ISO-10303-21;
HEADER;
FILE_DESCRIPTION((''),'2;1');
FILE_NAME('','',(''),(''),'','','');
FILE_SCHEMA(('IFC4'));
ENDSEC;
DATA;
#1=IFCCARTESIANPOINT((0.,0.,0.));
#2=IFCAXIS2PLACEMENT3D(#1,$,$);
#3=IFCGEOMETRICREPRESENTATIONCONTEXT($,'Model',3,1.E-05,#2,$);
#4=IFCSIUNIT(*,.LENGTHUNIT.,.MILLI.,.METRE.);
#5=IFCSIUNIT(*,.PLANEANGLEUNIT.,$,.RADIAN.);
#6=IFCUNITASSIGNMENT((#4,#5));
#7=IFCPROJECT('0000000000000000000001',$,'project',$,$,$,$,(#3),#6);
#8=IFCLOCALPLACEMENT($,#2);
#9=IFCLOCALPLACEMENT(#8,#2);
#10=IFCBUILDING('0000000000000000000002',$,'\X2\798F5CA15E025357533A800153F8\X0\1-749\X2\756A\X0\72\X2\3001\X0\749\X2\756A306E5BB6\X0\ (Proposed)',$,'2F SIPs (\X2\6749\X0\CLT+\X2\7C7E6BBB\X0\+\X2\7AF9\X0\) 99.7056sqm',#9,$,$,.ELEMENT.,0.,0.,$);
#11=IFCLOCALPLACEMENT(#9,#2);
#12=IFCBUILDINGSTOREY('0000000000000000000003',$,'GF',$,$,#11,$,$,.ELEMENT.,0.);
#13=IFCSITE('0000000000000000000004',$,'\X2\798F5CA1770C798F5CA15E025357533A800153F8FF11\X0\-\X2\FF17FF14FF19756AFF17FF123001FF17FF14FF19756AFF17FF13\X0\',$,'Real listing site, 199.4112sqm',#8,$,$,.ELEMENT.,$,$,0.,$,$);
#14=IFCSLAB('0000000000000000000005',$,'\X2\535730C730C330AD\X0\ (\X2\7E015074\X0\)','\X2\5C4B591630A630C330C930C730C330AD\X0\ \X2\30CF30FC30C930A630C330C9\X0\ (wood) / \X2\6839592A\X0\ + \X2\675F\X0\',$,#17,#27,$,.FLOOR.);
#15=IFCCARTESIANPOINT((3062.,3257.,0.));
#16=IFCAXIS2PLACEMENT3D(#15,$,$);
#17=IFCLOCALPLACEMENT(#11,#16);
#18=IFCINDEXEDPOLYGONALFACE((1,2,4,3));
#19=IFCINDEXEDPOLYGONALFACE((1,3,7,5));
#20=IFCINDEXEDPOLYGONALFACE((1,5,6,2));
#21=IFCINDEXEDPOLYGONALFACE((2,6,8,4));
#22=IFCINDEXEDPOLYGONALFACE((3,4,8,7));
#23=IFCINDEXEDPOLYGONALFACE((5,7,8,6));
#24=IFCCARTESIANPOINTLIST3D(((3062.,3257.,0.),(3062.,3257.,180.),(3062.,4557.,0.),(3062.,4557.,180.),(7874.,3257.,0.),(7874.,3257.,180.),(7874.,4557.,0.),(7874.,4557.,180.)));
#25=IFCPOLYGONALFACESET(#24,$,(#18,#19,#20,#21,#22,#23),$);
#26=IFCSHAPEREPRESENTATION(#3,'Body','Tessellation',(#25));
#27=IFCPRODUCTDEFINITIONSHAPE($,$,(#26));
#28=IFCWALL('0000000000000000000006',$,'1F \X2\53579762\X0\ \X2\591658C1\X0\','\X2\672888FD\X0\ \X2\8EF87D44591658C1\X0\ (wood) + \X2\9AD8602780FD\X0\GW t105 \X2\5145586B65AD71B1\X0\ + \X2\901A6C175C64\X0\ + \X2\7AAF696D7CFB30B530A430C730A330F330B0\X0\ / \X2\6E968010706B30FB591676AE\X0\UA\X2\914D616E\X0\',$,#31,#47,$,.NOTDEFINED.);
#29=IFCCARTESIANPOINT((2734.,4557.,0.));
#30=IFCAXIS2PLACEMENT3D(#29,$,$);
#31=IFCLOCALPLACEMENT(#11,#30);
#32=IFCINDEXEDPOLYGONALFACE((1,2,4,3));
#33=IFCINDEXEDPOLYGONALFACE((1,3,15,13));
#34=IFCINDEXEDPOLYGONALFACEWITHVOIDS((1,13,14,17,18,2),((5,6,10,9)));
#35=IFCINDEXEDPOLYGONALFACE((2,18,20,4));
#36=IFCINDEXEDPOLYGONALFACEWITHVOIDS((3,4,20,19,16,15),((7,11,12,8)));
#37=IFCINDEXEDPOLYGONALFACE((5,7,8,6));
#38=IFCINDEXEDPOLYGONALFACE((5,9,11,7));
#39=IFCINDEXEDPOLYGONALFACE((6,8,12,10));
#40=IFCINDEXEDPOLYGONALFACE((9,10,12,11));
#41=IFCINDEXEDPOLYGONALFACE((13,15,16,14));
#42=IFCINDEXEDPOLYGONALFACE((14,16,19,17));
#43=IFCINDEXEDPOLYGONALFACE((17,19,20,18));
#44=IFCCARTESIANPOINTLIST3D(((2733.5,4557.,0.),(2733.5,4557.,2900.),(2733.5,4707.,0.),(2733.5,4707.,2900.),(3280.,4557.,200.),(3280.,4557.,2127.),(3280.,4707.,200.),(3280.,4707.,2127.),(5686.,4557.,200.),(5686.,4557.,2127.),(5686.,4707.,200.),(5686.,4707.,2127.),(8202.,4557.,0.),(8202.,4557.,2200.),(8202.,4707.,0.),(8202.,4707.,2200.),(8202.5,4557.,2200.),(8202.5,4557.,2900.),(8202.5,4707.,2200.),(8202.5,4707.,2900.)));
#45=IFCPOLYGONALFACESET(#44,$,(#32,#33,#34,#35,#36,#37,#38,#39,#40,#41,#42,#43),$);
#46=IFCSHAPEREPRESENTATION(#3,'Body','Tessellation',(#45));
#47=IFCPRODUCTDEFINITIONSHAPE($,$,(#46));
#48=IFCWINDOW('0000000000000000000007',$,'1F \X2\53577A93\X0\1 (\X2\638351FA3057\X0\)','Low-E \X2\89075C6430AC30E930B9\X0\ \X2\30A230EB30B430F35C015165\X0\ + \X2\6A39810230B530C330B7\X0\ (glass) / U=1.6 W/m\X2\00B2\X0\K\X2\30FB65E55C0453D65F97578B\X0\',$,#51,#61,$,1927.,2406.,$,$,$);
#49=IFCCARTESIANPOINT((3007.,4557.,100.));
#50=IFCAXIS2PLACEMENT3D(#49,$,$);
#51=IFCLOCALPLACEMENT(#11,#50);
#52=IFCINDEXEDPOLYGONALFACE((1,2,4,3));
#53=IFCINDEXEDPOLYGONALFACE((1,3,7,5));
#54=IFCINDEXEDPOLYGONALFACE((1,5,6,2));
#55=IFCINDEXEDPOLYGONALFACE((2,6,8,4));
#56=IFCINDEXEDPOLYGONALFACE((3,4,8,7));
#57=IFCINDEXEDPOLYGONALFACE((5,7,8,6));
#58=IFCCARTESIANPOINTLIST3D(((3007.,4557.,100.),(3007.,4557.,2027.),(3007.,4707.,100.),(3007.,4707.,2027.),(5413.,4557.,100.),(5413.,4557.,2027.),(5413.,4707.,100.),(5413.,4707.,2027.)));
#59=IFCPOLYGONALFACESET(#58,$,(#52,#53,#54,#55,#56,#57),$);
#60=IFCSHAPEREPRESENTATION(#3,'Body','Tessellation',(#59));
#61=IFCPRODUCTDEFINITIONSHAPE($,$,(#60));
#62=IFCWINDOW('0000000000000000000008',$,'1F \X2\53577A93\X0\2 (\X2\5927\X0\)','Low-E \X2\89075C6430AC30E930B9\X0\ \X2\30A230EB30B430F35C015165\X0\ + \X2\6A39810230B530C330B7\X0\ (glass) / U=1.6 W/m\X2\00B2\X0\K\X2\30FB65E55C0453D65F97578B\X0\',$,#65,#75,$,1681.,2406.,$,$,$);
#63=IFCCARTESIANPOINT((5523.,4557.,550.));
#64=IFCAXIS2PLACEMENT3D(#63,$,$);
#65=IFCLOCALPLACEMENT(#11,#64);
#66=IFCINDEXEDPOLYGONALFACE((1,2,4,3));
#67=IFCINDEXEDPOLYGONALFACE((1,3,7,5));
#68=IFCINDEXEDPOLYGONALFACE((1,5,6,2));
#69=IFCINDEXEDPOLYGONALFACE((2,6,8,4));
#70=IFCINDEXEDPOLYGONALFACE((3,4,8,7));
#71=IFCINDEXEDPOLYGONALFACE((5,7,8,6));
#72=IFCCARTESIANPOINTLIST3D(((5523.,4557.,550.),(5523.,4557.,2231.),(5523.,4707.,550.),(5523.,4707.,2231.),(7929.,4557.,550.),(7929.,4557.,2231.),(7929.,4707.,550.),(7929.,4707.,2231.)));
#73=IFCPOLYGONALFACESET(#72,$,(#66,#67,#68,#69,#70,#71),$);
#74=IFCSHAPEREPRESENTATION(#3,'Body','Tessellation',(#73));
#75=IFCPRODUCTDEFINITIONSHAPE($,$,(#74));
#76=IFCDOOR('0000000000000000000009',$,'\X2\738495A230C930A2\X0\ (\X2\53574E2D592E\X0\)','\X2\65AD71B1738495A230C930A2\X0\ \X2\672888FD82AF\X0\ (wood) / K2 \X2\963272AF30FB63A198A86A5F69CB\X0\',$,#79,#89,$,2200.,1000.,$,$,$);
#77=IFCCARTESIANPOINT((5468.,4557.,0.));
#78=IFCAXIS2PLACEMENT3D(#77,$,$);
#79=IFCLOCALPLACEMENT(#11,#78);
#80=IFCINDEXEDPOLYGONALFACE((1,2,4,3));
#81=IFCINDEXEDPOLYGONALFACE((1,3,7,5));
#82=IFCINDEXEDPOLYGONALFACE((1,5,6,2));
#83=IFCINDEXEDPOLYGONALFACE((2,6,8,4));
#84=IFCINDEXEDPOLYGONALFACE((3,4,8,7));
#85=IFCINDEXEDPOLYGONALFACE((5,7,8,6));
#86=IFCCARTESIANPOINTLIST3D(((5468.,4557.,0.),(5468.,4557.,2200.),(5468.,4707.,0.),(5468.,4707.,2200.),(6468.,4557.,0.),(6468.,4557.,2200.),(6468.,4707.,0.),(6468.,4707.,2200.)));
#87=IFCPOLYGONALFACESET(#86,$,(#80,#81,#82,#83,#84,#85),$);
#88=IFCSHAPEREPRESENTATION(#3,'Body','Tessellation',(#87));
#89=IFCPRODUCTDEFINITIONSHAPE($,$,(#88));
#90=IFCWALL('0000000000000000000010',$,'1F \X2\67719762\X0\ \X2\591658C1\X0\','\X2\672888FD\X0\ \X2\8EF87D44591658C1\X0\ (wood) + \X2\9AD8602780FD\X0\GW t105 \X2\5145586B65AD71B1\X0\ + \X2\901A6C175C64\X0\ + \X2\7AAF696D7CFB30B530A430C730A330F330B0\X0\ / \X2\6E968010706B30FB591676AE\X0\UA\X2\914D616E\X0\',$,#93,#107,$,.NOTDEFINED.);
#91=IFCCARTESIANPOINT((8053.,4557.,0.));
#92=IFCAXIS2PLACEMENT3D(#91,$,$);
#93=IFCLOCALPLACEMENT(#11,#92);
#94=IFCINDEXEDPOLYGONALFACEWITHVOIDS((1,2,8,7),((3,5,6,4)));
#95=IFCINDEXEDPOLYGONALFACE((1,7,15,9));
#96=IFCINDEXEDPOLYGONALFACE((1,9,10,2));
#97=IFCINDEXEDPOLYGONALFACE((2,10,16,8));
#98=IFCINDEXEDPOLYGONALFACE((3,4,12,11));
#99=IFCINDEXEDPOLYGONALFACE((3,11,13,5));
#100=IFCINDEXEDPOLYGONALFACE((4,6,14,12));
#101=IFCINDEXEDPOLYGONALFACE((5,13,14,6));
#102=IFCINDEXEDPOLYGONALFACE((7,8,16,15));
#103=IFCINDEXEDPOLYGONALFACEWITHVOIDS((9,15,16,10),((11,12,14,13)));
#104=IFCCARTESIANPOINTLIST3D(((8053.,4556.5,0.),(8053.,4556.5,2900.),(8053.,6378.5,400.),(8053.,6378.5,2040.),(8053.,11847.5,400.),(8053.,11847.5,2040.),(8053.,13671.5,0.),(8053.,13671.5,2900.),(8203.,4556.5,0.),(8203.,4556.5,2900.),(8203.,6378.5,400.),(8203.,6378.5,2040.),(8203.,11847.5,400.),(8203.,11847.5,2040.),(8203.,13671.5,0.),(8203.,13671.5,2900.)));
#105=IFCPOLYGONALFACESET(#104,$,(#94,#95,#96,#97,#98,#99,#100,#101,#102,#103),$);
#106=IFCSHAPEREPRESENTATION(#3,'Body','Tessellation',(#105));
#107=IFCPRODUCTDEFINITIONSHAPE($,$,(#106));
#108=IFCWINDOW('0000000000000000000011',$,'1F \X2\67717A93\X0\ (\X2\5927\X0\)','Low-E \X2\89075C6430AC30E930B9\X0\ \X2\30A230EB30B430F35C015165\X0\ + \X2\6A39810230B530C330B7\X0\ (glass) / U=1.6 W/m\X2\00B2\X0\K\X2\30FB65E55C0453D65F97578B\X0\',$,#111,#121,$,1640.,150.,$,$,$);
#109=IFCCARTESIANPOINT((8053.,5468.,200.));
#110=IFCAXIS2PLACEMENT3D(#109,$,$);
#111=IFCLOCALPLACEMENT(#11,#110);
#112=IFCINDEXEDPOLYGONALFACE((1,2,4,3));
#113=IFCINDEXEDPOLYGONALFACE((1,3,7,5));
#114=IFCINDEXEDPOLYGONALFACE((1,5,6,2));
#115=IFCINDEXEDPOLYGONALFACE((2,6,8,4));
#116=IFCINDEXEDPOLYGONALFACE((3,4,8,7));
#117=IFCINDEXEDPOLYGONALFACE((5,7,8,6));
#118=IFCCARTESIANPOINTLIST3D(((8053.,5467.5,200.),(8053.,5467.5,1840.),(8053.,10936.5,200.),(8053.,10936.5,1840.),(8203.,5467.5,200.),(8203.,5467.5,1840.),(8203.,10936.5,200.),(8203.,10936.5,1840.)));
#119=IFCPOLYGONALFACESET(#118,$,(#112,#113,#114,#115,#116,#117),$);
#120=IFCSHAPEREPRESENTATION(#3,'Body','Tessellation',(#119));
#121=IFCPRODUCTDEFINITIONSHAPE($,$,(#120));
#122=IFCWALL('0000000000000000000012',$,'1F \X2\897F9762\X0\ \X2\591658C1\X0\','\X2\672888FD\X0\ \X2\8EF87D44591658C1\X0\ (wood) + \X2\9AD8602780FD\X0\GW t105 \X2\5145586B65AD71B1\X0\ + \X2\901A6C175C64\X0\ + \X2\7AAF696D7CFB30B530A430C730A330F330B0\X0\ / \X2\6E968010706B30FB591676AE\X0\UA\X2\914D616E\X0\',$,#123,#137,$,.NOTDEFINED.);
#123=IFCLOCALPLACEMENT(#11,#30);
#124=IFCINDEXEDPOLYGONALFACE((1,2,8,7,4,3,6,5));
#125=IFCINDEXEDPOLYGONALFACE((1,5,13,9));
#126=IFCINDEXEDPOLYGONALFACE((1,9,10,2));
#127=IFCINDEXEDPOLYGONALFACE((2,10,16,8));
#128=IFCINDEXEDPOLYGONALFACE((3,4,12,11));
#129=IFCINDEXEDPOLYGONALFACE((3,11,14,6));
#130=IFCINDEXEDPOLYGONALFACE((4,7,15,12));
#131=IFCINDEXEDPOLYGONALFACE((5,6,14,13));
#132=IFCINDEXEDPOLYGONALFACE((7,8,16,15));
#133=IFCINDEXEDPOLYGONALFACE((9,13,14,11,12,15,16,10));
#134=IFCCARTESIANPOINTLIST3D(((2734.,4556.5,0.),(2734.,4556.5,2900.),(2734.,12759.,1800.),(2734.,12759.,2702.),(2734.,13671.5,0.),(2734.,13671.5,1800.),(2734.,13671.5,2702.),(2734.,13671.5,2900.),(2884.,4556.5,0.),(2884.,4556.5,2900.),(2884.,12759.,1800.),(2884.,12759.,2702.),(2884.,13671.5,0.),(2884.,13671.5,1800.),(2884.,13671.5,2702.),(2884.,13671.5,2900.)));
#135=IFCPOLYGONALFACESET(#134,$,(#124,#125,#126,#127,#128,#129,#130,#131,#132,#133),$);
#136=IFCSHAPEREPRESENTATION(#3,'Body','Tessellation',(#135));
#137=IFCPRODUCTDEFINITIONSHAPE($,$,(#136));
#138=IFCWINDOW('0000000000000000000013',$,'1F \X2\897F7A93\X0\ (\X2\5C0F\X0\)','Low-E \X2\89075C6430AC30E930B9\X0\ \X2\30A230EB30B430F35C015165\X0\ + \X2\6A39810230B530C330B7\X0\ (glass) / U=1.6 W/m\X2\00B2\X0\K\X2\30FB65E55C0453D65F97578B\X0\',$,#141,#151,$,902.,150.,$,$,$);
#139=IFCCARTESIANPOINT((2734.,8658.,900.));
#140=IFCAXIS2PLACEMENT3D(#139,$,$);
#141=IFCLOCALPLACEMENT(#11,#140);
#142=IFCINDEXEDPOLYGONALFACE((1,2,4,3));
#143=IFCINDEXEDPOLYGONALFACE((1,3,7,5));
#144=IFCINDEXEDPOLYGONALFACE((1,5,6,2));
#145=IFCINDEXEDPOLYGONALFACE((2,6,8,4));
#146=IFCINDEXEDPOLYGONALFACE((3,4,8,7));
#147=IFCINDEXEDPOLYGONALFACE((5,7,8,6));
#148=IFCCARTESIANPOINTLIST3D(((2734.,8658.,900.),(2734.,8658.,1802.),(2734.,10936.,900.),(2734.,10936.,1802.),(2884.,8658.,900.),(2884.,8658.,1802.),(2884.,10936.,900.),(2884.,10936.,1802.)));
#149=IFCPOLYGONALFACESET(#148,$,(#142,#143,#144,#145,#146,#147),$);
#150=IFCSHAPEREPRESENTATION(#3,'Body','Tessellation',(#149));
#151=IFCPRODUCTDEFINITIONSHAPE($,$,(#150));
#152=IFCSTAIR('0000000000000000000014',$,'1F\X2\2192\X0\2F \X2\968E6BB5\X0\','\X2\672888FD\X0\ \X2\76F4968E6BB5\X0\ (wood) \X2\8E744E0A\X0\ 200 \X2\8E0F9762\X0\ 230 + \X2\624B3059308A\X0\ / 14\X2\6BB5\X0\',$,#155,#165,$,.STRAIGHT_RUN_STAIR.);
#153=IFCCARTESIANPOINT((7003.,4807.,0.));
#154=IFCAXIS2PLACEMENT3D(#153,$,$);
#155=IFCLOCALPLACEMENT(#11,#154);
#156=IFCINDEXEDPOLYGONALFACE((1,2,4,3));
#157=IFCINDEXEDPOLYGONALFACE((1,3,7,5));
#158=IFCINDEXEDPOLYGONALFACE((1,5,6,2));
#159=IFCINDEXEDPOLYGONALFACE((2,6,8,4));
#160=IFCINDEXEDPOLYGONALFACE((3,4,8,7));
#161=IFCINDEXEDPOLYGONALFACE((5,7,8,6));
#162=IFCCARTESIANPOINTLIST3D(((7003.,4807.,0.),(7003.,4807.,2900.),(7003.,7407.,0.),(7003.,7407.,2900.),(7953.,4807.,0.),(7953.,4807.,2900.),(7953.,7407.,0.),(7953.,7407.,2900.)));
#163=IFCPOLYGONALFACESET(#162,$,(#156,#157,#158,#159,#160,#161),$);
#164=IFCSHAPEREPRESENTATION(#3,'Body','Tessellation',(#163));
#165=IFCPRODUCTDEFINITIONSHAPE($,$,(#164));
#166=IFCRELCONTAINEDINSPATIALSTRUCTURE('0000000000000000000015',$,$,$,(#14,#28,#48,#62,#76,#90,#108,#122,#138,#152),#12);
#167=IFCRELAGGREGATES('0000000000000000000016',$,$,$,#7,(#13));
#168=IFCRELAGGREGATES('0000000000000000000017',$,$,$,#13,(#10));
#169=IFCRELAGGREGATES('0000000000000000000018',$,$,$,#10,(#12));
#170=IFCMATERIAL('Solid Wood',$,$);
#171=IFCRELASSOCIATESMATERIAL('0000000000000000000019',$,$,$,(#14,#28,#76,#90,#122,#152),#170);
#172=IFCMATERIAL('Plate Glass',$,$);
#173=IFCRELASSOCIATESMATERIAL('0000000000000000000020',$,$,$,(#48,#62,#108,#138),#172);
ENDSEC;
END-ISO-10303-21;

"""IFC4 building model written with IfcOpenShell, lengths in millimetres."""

from ifc_helpers import new_model, si_unit, frame, frame_2d, origin, place, context, project, spatial, rectangle, extrude, material, element, fill, save


model = new_model("IFC4")

# Units and contexts
model_context = context("Model", 3, precision=1e-05, world=origin())
ifc_project = project(units=[si_unit("LENGTHUNIT", "METRE", prefix="MILLI"), si_unit("PLANEANGLEUNIT", "RADIAN")], contexts=[model_context])

# Site, building, storey
site_placement = place(None, origin())
site = spatial("IfcSite", under=ifc_project, at=site_placement, Name="福岡県福岡市南区老司１-７４９番７２、７４９番７３", ObjectType="Real listing site, 199.4112sqm", CompositionType="ELEMENT", RefElevation=0.0)
building_placement = place(site_placement, origin())
building = spatial("IfcBuilding", under=site, at=building_placement, Name="福岡市南区老司1-749番72、749番の家 (Proposed)", ObjectType="2F SIPs (杉CLT+籾殻+竹) 99.7056sqm", CompositionType="ELEMENT", ElevationOfRefHeight=0.0, ElevationOfTerrain=0.0)
storey_placement = place(building_placement, origin())
storey = spatial("IfcBuildingStorey", under=building, at=storey_placement, Name="GF", CompositionType="ELEMENT", Elevation=0.0)

# Slab
ifc_material_1 = material(Name="Solid Wood")
slab_1_placement = place(storey_placement, frame((3062.0, 3257.0, 0.0)))
element("IfcSlab", 1, at=slab_1_placement, inside=storey, material=ifc_material_1, Name="南デッキ (縁側)", Description="屋外ウッドデッキ ハードウッド (wood) / 根太 + 束", PredefinedType="FLOOR", context=model_context, shape_type="SweptSolid", body=[
    extrude(rectangle(XDim=4812.0, YDim=1300.0, at=frame_2d((2406.0, 650.0))), frame((3062.0, 3257.0, 0.0)), (0.0, 0.0, 1.0), 180.0),
])

# Wall, openings, windows, door
wall_1_placement = place(storey_placement, frame((2734.0, 4557.0, 0.0)))
wall_1 = element("IfcWall", 2, at=wall_1_placement, inside=storey, material=ifc_material_1, Name="1F 南面 外壁", Description="木製 軸組外壁 (wood) + 高性能GW t105 充填断熱 + 通気層 + 窯業系サイディング / 準耐火・外皮UA配慮", PredefinedType="NOTDEFINED", context=model_context, shape_type="SweptSolid", body=[
    extrude(rectangle(XDim=5469.0, YDim=150.0, at=frame_2d((2734.0, 75.0))), frame((2734.0, 4557.0, 0.0)), (0.0, 0.0, 1.0), 2900.0),
])
opening_1_placement = place(storey_placement, frame((3007.0, 4557.0, 100.0)))
opening_1 = element("IfcOpeningElement", 3, at=opening_1_placement, cuts=wall_1, PredefinedType="NOTDEFINED", context=model_context, shape_type="SweptSolid", body=[
    extrude(rectangle(XDim=2406.0, YDim=150.0, at=frame_2d((1203.0, 75.0))), frame((3007.0, 4557.0, 100.0)), (0.0, 0.0, 1.0), 1927.0),
])
opening_2_placement = place(storey_placement, frame((5523.0, 4557.0, 550.0)))
opening_2 = element("IfcOpeningElement", 4, at=opening_2_placement, cuts=wall_1, PredefinedType="NOTDEFINED", context=model_context, shape_type="SweptSolid", body=[
    extrude(rectangle(XDim=2406.0, YDim=150.0, at=frame_2d((1203.0, 75.0))), frame((5523.0, 4557.0, 550.0)), (0.0, 0.0, 1.0), 1681.0),
])
opening_3_placement = place(storey_placement, frame((5468.0, 4557.0, 0.0)))
opening_3 = element("IfcOpeningElement", 5, at=opening_3_placement, cuts=wall_1, PredefinedType="NOTDEFINED", context=model_context, shape_type="SweptSolid", body=[
    extrude(rectangle(XDim=1000.0, YDim=150.0, at=frame_2d((500.0, 75.0))), frame((5468.0, 4557.0, 0.0)), (0.0, 0.0, 1.0), 2200.0),
])
ifc_material_2 = material(Name="Plate Glass")
window_1_placement = place(storey_placement, frame((3007.0, 4557.0, 100.0)))
window_1 = element("IfcWindow", 6, at=window_1_placement, inside=storey, material=ifc_material_2, Name="1F 南窓1 (掃出し)", Description="Low-E 複層ガラス アルゴン封入 + 樹脂サッシ (glass) / U=1.6 W/m²K・日射取得型", OverallHeight=1927.0, OverallWidth=2406.0, context=model_context, shape_type="SweptSolid", body=[
    extrude(rectangle(XDim=2406.0, YDim=150.0, at=frame_2d((1203.0, 75.0))), frame((3007.0, 4557.0, 100.0)), (0.0, 0.0, 1.0), 1927.0),
])
fill(opening_1, window_1)
window_2_placement = place(storey_placement, frame((5523.0, 4557.0, 550.0)))
window_2 = element("IfcWindow", 7, at=window_2_placement, inside=storey, material=ifc_material_2, Name="1F 南窓2 (大)", Description="Low-E 複層ガラス アルゴン封入 + 樹脂サッシ (glass) / U=1.6 W/m²K・日射取得型", OverallHeight=1681.0, OverallWidth=2406.0, context=model_context, shape_type="SweptSolid", body=[
    extrude(rectangle(XDim=2406.0, YDim=150.0, at=frame_2d((1203.0, 75.0))), frame((5523.0, 4557.0, 550.0)), (0.0, 0.0, 1.0), 1681.0),
])
fill(opening_2, window_2)
door_placement = place(storey_placement, frame((5468.0, 4557.0, 0.0)))
door = element("IfcDoor", 8, at=door_placement, inside=storey, material=ifc_material_1, Name="玄関ドア (南中央)", Description="断熱玄関ドア 木製芯 (wood) / K2 防犯・採風機構", OverallHeight=2200.0, OverallWidth=1000.0, context=model_context, shape_type="SweptSolid", body=[
    extrude(rectangle(XDim=1000.0, YDim=150.0, at=frame_2d((500.0, 75.0))), frame((5468.0, 4557.0, 0.0)), (0.0, 0.0, 1.0), 2200.0),
])
fill(opening_3, door)

# Walls, openings, windows
wall_2_placement = place(storey_placement, frame((8053.0, 4557.0, 0.0)))
wall_2 = element("IfcWall", 9, at=wall_2_placement, inside=storey, material=ifc_material_1, Name="1F 東面 外壁", Description="木製 軸組外壁 (wood) + 高性能GW t105 充填断熱 + 通気層 + 窯業系サイディング / 準耐火・外皮UA配慮", PredefinedType="NOTDEFINED", context=model_context, shape_type="SweptSolid", body=[
    extrude(rectangle(XDim=150.0, YDim=9115.0, at=frame_2d((75.0, 4557.0))), frame((8053.0, 4557.0, 0.0)), (0.0, 0.0, 1.0), 2900.0),
])
opening_4_placement = place(storey_placement, frame((8053.0, 5468.0, 200.0)))
opening_4 = element("IfcOpeningElement", 10, at=opening_4_placement, cuts=wall_2, PredefinedType="NOTDEFINED", context=model_context, shape_type="SweptSolid", body=[
    extrude(rectangle(XDim=150.0, YDim=5469.0, at=frame_2d((75.0, 2734.0))), frame((8053.0, 5468.0, 200.0)), (0.0, 0.0, 1.0), 1640.0),
])
window_3_placement = place(storey_placement, frame((8053.0, 5468.0, 200.0)))
window_3 = element("IfcWindow", 11, at=window_3_placement, inside=storey, material=ifc_material_2, Name="1F 東窓 (大)", Description="Low-E 複層ガラス アルゴン封入 + 樹脂サッシ (glass) / U=1.6 W/m²K・日射取得型", OverallHeight=1640.0, OverallWidth=150.0, context=model_context, shape_type="SweptSolid", body=[
    extrude(rectangle(XDim=150.0, YDim=5469.0, at=frame_2d((75.0, 2734.0))), frame((8053.0, 5468.0, 200.0)), (0.0, 0.0, 1.0), 1640.0),
])
fill(opening_4, window_3)
wall_3_placement = place(storey_placement, frame((2734.0, 4557.0, 0.0)))
wall_3 = element("IfcWall", 12, at=wall_3_placement, inside=storey, material=ifc_material_1, Name="1F 西面 外壁", Description="木製 軸組外壁 (wood) + 高性能GW t105 充填断熱 + 通気層 + 窯業系サイディング / 準耐火・外皮UA配慮", PredefinedType="NOTDEFINED", context=model_context, shape_type="SweptSolid", body=[
    extrude(rectangle(XDim=150.0, YDim=9115.0, at=frame_2d((75.0, 4557.0))), frame((2734.0, 4557.0, 0.0)), (0.0, 0.0, 1.0), 2900.0),
])
opening_5_placement = place(storey_placement, frame((2734.0, 8658.0, 900.0)))
opening_5 = element("IfcOpeningElement", 13, at=opening_5_placement, cuts=wall_3, PredefinedType="NOTDEFINED", context=model_context, shape_type="SweptSolid", body=[
    extrude(rectangle(XDim=150.0, YDim=2278.0, at=frame_2d((75.0, 1139.0))), frame((2734.0, 8658.0, 900.0)), (0.0, 0.0, 1.0), 902.0),
])
window_4_placement = place(storey_placement, frame((2734.0, 8658.0, 900.0)))
window_4 = element("IfcWindow", 14, at=window_4_placement, inside=storey, material=ifc_material_2, Name="1F 西窓 (小)", Description="Low-E 複層ガラス アルゴン封入 + 樹脂サッシ (glass) / U=1.6 W/m²K・日射取得型", OverallHeight=902.0, OverallWidth=150.0, context=model_context, shape_type="SweptSolid", body=[
    extrude(rectangle(XDim=150.0, YDim=2278.0, at=frame_2d((75.0, 1139.0))), frame((2734.0, 8658.0, 900.0)), (0.0, 0.0, 1.0), 902.0),
])
fill(opening_5, window_4)

# Stair
stair_placement = place(storey_placement, frame((7003.0, 4807.0, 0.0)))
element("IfcStair", 15, at=stair_placement, inside=storey, material=ifc_material_1, Name="1F→2F 階段", Description="木製 直階段 (wood) 蹴上 200 踏面 230 + 手すり / 14段", PredefinedType="STRAIGHT_RUN_STAIR", context=model_context, shape_type="SweptSolid", body=[
    extrude(rectangle(XDim=950.0, YDim=2600.0, at=frame_2d((475.0, 1300.0))), frame((7003.0, 4807.0, 0.0)), (0.0, 0.0, 1.0), 2900.0),
])

save(model, "model.ifc")
